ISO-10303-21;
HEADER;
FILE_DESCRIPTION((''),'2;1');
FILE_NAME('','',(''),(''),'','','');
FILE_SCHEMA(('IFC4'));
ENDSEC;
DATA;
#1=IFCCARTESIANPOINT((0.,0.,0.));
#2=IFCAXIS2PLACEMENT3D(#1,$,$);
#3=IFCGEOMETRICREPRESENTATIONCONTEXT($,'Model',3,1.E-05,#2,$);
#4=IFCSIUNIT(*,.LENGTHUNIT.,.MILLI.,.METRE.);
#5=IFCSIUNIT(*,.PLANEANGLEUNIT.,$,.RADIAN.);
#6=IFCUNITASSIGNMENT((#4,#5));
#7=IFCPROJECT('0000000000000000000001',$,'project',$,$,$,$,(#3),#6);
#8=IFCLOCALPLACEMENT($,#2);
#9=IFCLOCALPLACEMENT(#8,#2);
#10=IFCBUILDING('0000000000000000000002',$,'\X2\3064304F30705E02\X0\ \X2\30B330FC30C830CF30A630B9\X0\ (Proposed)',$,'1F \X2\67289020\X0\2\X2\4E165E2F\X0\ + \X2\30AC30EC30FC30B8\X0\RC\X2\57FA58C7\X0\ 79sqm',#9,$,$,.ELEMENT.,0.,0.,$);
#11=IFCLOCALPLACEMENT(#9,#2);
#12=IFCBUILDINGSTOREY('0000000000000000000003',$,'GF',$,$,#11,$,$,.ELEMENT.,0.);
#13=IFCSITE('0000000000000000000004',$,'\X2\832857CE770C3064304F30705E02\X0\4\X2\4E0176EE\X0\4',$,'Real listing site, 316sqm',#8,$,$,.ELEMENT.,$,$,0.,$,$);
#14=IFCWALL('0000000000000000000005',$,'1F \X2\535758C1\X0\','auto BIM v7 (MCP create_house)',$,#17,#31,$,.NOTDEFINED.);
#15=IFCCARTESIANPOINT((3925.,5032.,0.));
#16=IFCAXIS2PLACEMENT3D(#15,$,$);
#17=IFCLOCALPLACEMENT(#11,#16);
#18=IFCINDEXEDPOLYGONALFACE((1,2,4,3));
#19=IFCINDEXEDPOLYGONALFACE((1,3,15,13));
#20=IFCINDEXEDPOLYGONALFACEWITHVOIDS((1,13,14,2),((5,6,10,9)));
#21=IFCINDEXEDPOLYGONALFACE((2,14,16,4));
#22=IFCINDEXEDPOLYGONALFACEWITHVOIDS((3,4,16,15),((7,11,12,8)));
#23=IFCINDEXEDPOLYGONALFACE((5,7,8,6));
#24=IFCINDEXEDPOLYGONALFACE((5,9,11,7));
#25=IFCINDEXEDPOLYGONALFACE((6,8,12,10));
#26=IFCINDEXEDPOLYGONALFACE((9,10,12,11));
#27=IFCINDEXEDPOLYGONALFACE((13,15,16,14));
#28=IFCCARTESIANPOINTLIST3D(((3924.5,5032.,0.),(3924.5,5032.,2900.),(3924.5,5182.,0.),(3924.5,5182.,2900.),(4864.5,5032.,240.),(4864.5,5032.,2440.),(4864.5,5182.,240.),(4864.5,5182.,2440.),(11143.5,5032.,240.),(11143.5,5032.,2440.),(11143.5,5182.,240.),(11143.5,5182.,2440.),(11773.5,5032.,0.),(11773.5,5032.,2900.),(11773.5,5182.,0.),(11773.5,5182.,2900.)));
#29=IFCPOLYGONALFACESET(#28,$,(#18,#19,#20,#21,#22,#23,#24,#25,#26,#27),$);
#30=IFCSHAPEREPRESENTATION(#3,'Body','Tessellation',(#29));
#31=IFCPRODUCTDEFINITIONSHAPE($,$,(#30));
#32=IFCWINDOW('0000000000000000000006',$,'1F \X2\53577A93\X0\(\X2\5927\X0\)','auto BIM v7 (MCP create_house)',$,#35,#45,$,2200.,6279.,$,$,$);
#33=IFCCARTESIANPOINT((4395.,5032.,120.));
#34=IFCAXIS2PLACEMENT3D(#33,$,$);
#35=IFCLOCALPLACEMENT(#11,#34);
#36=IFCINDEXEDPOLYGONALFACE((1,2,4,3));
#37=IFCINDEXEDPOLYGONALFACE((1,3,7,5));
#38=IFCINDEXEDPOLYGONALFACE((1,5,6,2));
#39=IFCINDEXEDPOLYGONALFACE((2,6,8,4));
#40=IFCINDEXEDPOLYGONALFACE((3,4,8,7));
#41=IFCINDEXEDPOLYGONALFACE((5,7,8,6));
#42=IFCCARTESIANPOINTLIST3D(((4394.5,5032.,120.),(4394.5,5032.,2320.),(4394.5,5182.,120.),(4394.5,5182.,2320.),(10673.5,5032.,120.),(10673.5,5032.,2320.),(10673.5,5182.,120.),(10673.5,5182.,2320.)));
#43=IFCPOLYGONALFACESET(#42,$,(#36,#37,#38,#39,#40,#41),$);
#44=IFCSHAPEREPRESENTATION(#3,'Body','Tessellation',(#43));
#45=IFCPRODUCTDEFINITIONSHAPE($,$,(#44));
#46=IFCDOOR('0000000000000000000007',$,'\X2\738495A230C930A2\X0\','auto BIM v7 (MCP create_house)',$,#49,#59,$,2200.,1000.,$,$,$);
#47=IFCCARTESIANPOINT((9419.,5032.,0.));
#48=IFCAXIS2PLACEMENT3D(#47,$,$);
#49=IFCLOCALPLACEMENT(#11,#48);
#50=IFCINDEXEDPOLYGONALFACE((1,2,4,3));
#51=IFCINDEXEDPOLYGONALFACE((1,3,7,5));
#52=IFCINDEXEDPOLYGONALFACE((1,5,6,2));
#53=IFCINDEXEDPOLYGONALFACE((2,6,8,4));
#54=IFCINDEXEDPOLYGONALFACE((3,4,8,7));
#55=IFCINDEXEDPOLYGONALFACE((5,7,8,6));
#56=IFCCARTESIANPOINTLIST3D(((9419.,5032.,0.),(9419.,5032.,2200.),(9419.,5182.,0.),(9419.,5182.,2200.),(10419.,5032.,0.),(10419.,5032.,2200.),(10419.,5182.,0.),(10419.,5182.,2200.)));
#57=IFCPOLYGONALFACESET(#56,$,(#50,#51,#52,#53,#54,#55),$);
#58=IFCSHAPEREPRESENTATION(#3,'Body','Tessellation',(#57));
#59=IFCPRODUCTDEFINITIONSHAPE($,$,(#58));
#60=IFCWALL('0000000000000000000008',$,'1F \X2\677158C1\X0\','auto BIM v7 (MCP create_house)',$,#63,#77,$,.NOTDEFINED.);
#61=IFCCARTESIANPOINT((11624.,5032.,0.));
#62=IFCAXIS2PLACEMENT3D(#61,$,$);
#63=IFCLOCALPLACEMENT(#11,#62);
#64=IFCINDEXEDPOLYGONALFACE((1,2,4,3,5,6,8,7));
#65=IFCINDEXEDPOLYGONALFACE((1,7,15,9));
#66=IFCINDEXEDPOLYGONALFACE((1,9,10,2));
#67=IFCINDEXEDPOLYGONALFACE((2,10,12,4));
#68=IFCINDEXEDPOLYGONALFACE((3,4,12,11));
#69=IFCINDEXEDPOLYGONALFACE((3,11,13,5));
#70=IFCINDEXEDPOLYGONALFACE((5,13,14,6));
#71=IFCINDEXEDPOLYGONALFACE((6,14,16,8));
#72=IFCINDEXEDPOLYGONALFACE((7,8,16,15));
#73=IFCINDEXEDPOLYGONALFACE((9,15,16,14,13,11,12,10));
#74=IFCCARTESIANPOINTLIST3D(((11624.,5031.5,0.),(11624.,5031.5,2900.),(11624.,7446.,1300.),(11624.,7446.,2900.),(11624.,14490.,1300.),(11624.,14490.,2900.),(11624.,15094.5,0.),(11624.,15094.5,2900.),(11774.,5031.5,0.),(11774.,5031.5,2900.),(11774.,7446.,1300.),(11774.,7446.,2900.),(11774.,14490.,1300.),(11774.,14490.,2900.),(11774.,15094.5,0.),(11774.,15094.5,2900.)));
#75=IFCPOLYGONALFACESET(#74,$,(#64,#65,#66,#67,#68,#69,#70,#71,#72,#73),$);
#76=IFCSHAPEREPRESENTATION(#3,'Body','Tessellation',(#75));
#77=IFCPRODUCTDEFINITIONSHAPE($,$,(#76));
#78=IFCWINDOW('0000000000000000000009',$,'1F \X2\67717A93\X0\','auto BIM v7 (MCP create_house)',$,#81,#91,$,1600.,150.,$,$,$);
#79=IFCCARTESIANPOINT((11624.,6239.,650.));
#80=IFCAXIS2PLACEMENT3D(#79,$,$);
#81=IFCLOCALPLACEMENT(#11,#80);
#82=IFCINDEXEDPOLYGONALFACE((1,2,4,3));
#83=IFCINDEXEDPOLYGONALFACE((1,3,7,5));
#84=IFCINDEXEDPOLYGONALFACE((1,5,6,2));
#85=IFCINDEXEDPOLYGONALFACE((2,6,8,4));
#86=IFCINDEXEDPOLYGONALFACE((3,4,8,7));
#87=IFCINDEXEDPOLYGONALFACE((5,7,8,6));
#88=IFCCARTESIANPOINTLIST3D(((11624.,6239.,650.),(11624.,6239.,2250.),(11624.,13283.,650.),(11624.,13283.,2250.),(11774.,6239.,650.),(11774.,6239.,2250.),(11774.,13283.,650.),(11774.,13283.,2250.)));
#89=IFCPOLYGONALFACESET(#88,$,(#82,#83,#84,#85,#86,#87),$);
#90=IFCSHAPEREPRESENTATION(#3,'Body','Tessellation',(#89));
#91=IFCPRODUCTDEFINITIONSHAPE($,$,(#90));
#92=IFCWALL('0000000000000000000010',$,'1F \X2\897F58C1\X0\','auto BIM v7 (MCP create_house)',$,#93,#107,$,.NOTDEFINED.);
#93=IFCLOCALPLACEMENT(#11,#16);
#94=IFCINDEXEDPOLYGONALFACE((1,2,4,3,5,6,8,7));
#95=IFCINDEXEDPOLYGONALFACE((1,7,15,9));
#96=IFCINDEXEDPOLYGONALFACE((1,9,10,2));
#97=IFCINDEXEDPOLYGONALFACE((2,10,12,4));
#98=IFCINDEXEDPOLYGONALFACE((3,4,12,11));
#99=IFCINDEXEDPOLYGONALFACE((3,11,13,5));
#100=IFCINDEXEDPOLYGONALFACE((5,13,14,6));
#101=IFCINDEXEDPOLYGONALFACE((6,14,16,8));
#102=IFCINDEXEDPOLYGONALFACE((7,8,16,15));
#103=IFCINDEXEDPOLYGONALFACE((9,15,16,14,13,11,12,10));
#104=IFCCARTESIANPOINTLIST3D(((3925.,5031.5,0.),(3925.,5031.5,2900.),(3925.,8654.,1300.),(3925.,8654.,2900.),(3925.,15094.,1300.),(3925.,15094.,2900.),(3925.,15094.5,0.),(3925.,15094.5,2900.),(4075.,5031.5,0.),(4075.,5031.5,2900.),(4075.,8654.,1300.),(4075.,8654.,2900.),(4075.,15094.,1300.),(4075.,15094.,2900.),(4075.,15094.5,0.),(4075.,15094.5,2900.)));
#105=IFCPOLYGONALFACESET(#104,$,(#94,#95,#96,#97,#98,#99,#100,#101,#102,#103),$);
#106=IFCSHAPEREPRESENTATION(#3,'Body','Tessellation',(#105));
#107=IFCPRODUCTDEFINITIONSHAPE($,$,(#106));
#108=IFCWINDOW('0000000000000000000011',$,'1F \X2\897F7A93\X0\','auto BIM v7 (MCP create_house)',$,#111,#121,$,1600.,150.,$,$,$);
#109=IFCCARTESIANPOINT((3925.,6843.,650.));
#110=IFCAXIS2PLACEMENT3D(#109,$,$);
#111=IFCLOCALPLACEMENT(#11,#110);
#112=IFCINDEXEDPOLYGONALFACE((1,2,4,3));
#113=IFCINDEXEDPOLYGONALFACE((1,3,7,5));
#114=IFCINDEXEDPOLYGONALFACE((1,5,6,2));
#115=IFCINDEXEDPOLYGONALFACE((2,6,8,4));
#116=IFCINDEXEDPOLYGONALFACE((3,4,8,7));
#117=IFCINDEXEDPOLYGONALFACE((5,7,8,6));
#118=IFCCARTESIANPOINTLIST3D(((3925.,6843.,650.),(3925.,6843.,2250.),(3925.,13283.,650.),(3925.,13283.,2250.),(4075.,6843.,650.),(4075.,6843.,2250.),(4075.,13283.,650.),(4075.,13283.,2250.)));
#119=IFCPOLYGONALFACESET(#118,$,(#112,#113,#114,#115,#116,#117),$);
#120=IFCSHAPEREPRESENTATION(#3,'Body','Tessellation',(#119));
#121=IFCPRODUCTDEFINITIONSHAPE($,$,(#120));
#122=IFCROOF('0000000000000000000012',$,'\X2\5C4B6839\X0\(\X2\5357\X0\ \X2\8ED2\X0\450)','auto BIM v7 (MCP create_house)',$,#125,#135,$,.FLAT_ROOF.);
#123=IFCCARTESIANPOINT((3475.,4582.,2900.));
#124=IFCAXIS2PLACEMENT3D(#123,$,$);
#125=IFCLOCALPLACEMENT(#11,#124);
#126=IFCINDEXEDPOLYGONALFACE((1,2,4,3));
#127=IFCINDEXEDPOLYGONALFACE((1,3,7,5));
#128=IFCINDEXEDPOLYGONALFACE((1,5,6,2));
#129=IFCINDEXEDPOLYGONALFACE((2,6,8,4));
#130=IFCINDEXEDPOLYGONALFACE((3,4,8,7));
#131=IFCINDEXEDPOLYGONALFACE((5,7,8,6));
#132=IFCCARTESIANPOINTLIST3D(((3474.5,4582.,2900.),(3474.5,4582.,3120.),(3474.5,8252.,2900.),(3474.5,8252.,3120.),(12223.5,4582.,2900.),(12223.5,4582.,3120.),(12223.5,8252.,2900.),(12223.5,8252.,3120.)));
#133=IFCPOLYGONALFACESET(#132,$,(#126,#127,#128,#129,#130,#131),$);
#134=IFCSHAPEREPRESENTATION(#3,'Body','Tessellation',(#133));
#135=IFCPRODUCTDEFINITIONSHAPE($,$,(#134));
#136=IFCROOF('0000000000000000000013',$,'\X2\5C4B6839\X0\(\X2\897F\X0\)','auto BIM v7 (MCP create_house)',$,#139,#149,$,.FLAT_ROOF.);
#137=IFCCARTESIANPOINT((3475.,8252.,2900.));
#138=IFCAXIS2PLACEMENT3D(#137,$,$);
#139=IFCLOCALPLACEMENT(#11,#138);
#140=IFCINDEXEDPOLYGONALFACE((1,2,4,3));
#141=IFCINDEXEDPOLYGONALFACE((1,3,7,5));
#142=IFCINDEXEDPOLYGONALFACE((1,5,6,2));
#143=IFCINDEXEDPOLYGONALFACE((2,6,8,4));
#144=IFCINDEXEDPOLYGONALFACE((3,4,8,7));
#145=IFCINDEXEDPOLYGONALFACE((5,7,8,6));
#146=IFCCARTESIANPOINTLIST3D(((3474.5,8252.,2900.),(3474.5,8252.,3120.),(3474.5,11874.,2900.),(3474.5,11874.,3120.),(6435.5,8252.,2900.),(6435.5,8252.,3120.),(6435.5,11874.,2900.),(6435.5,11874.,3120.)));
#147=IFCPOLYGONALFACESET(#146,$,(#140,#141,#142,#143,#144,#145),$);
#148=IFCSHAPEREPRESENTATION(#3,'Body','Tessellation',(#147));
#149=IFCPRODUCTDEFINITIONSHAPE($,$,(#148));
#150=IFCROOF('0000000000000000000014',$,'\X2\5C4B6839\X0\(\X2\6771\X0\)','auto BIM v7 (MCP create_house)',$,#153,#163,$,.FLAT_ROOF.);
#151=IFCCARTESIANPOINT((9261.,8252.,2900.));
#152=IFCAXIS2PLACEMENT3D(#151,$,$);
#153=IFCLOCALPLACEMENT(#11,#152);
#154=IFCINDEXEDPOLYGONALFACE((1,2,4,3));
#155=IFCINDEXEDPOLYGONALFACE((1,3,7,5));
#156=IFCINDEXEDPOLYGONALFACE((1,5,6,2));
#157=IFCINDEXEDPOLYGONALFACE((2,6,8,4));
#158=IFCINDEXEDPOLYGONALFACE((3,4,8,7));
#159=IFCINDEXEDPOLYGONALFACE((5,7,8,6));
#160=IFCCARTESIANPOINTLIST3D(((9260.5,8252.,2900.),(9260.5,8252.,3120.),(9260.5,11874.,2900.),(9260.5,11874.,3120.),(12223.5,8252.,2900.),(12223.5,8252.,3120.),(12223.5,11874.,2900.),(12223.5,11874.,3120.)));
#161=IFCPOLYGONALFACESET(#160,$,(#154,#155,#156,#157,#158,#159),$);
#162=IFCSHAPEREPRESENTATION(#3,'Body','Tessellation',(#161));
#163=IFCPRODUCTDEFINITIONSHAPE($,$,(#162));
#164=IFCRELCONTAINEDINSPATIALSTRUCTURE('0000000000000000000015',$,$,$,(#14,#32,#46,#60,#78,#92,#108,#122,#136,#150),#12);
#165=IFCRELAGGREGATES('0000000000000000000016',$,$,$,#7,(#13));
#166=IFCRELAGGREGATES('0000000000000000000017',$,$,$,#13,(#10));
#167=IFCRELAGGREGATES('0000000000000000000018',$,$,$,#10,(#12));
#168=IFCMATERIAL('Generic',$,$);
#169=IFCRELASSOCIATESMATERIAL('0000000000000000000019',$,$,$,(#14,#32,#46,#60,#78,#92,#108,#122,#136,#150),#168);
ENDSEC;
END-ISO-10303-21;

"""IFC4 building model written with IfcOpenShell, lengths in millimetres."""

from ifc_helpers import new_model, si_unit, frame, frame_2d, origin, place, context, project, spatial, rectangle, extrude, material, element, fill, save


model = new_model("IFC4")

# Units and contexts
model_context = context("Model", 3, precision=1e-05, world=origin())
ifc_project = project(units=[si_unit("LENGTHUNIT", "METRE", prefix="MILLI"), si_unit("PLANEANGLEUNIT", "RADIAN")], contexts=[model_context])

# Site, building, storey
site_placement = place(None, origin())
site = spatial("IfcSite", under=ifc_project, at=site_placement, Name="茨城県つくば市4丁目4", ObjectType="Real listing site, 316sqm", CompositionType="ELEMENT", RefElevation=0.0)
building_placement = place(site_placement, origin())
building = spatial("IfcBuilding", under=site, at=building_placement, Name="つくば市 コートハウス (Proposed)", ObjectType="1F 木造2世帯 + ガレージRC基壇 79sqm", CompositionType="ELEMENT", ElevationOfRefHeight=0.0, ElevationOfTerrain=0.0)
storey_placement = place(building_placement, origin())
storey = spatial("IfcBuildingStorey", under=building, at=storey_placement, Name="GF", CompositionType="ELEMENT", Elevation=0.0)

# Shared definitions
ifc_material = material(Name="Generic")

# Wall, openings, window, door
wall_1_placement = place(storey_placement, frame((3925.0, 5032.0, 0.0)))
wall_1 = element("IfcWall", 1, at=wall_1_placement, inside=storey, material=ifc_material, Name="1F 南壁", Description="auto BIM v7 (MCP create_house)", PredefinedType="NOTDEFINED", context=model_context, shape_type="SweptSolid", body=[
    extrude(rectangle(XDim=7849.0, YDim=150.0, at=frame_2d((3924.0, 75.0))), frame((3925.0, 5032.0, 0.0)), (0.0, 0.0, 1.0), 2900.0),
])
opening_1_placement = place(storey_placement, frame((4395.0, 5032.0, 120.0)))
opening_1 = element("IfcOpeningElement", 2, at=opening_1_placement, cuts=wall_1, PredefinedType="NOTDEFINED", context=model_context, shape_type="SweptSolid", body=[
    extrude(rectangle(XDim=6279.0, YDim=150.0, at=frame_2d((3139.0, 75.0))), frame((4395.0, 5032.0, 120.0)), (0.0, 0.0, 1.0), 2200.0),
])
opening_2_placement = place(storey_placement, frame((9419.0, 5032.0, 0.0)))
opening_2 = element("IfcOpeningElement", 3, at=opening_2_placement, cuts=wall_1, PredefinedType="NOTDEFINED", context=model_context, shape_type="SweptSolid", body=[
    extrude(rectangle(XDim=1000.0, YDim=150.0, at=frame_2d((500.0, 75.0))), frame((9419.0, 5032.0, 0.0)), (0.0, 0.0, 1.0), 2200.0),
])
window_1_placement = place(storey_placement, frame((4395.0, 5032.0, 120.0)))
window_1 = element("IfcWindow", 4, at=window_1_placement, inside=storey, material=ifc_material, Name="1F 南窓(大)", Description="auto BIM v7 (MCP create_house)", OverallHeight=2200.0, OverallWidth=6279.0, context=model_context, shape_type="SweptSolid", body=[
    extrude(rectangle(XDim=6279.0, YDim=150.0, at=frame_2d((3139.0, 75.0))), frame((4395.0, 5032.0, 120.0)), (0.0, 0.0, 1.0), 2200.0),
])
fill(opening_1, window_1)
door_placement = place(storey_placement, frame((9419.0, 5032.0, 0.0)))
door = element("IfcDoor", 5, at=door_placement, inside=storey, material=ifc_material, Name="玄関ドア", Description="auto BIM v7 (MCP create_house)", OverallHeight=2200.0, OverallWidth=1000.0, context=model_context, shape_type="SweptSolid", body=[
    extrude(rectangle(XDim=1000.0, YDim=150.0, at=frame_2d((500.0, 75.0))), frame((9419.0, 5032.0, 0.0)), (0.0, 0.0, 1.0), 2200.0),
])
fill(opening_2, door)

# Walls, openings, windows
wall_2_placement = place(storey_placement, frame((11624.0, 5032.0, 0.0)))
wall_2 = element("IfcWall", 6, at=wall_2_placement, inside=storey, material=ifc_material, Name="1F 東壁", Description="auto BIM v7 (MCP create_house)", PredefinedType="NOTDEFINED", context=model_context, shape_type="SweptSolid", body=[
    extrude(rectangle(XDim=150.0, YDim=10063.0, at=frame_2d((75.0, 5031.0))), frame((11624.0, 5032.0, 0.0)), (0.0, 0.0, 1.0), 2900.0),
])
opening_3_placement = place(storey_placement, frame((11624.0, 6239.0, 650.0)))
opening_3 = element("IfcOpeningElement", 7, at=opening_3_placement, cuts=wall_2, PredefinedType="NOTDEFINED", context=model_context, shape_type="SweptSolid", body=[
    extrude(rectangle(XDim=150.0, YDim=7044.0, at=frame_2d((75.0, 3522.0))), frame((11624.0, 6239.0, 650.0)), (0.0, 0.0, 1.0), 1600.0),
])
window_2_placement = place(storey_placement, frame((11624.0, 6239.0, 650.0)))
window_2 = element("IfcWindow", 8, at=window_2_placement, inside=storey, material=ifc_material, Name="1F 東窓", Description="auto BIM v7 (MCP create_house)", OverallHeight=1600.0, OverallWidth=150.0, context=model_context, shape_type="SweptSolid", body=[
    extrude(rectangle(XDim=150.0, YDim=7044.0, at=frame_2d((75.0, 3522.0))), frame((11624.0, 6239.0, 650.0)), (0.0, 0.0, 1.0), 1600.0),
])
fill(opening_3, window_2)
wall_3_placement = place(storey_placement, frame((3925.0, 5032.0, 0.0)))
wall_3 = element("IfcWall", 9, at=wall_3_placement, inside=storey, material=ifc_material, Name="1F 西壁", Description="auto BIM v7 (MCP create_house)", PredefinedType="NOTDEFINED", context=model_context, shape_type="SweptSolid", body=[
    extrude(rectangle(XDim=150.0, YDim=10063.0, at=frame_2d((75.0, 5031.0))), frame((3925.0, 5032.0, 0.0)), (0.0, 0.0, 1.0), 2900.0),
])
opening_4_placement = place(storey_placement, frame((3925.0, 6843.0, 650.0)))
opening_4 = element("IfcOpeningElement", 10, at=opening_4_placement, cuts=wall_3, PredefinedType="NOTDEFINED", context=model_context, shape_type="SweptSolid", body=[
    extrude(rectangle(XDim=150.0, YDim=6440.0, at=frame_2d((75.0, 3220.0))), frame((3925.0, 6843.0, 650.0)), (0.0, 0.0, 1.0), 1600.0),
])
window_3_placement = place(storey_placement, frame((3925.0, 6843.0, 650.0)))
window_3 = element("IfcWindow", 11, at=window_3_placement, inside=storey, material=ifc_material, Name="1F 西窓", Description="auto BIM v7 (MCP create_house)", OverallHeight=1600.0, OverallWidth=150.0, context=model_context, shape_type="SweptSolid", body=[
    extrude(rectangle(XDim=150.0, YDim=6440.0, at=frame_2d((75.0, 3220.0))), frame((3925.0, 6843.0, 650.0)), (0.0, 0.0, 1.0), 1600.0),
])
fill(opening_4, window_3)

# Roofs
roof_1_placement = place(storey_placement, frame((3475.0, 4582.0, 2900.0)))
element("IfcRoof", 12, at=roof_1_placement, inside=storey, material=ifc_material, Name="屋根(南 軒450)", Description="auto BIM v7 (MCP create_house)", PredefinedType="FLAT_ROOF", context=model_context, shape_type="SweptSolid", body=[
    extrude(rectangle(XDim=8749.0, YDim=3670.0, at=frame_2d((4374.0, 1835.0))), frame((3475.0, 4582.0, 2900.0)), (0.0, 0.0, 1.0), 220.0),
])
roof_2_placement = place(storey_placement, frame((3475.0, 8252.0, 2900.0)))
element("IfcRoof", 13, at=roof_2_placement, inside=storey, material=ifc_material, Name="屋根(西)", Description="auto BIM v7 (MCP create_house)", PredefinedType="FLAT_ROOF", context=model_context, shape_type="SweptSolid", body=[
    extrude(rectangle(XDim=2961.0, YDim=3622.0, at=frame_2d((1480.0, 1811.0))), frame((3475.0, 8252.0, 2900.0)), (0.0, 0.0, 1.0), 220.0),
])
roof_3_placement = place(storey_placement, frame((9261.0, 8252.0, 2900.0)))
element("IfcRoof", 14, at=roof_3_placement, inside=storey, material=ifc_material, Name="屋根(東)", Description="auto BIM v7 (MCP create_house)", PredefinedType="FLAT_ROOF", context=model_context, shape_type="SweptSolid", body=[
    extrude(rectangle(XDim=2963.0, YDim=3622.0, at=frame_2d((1481.0, 1811.0))), frame((9261.0, 8252.0, 2900.0)), (0.0, 0.0, 1.0), 220.0),
])

save(model, "model.ifc")
